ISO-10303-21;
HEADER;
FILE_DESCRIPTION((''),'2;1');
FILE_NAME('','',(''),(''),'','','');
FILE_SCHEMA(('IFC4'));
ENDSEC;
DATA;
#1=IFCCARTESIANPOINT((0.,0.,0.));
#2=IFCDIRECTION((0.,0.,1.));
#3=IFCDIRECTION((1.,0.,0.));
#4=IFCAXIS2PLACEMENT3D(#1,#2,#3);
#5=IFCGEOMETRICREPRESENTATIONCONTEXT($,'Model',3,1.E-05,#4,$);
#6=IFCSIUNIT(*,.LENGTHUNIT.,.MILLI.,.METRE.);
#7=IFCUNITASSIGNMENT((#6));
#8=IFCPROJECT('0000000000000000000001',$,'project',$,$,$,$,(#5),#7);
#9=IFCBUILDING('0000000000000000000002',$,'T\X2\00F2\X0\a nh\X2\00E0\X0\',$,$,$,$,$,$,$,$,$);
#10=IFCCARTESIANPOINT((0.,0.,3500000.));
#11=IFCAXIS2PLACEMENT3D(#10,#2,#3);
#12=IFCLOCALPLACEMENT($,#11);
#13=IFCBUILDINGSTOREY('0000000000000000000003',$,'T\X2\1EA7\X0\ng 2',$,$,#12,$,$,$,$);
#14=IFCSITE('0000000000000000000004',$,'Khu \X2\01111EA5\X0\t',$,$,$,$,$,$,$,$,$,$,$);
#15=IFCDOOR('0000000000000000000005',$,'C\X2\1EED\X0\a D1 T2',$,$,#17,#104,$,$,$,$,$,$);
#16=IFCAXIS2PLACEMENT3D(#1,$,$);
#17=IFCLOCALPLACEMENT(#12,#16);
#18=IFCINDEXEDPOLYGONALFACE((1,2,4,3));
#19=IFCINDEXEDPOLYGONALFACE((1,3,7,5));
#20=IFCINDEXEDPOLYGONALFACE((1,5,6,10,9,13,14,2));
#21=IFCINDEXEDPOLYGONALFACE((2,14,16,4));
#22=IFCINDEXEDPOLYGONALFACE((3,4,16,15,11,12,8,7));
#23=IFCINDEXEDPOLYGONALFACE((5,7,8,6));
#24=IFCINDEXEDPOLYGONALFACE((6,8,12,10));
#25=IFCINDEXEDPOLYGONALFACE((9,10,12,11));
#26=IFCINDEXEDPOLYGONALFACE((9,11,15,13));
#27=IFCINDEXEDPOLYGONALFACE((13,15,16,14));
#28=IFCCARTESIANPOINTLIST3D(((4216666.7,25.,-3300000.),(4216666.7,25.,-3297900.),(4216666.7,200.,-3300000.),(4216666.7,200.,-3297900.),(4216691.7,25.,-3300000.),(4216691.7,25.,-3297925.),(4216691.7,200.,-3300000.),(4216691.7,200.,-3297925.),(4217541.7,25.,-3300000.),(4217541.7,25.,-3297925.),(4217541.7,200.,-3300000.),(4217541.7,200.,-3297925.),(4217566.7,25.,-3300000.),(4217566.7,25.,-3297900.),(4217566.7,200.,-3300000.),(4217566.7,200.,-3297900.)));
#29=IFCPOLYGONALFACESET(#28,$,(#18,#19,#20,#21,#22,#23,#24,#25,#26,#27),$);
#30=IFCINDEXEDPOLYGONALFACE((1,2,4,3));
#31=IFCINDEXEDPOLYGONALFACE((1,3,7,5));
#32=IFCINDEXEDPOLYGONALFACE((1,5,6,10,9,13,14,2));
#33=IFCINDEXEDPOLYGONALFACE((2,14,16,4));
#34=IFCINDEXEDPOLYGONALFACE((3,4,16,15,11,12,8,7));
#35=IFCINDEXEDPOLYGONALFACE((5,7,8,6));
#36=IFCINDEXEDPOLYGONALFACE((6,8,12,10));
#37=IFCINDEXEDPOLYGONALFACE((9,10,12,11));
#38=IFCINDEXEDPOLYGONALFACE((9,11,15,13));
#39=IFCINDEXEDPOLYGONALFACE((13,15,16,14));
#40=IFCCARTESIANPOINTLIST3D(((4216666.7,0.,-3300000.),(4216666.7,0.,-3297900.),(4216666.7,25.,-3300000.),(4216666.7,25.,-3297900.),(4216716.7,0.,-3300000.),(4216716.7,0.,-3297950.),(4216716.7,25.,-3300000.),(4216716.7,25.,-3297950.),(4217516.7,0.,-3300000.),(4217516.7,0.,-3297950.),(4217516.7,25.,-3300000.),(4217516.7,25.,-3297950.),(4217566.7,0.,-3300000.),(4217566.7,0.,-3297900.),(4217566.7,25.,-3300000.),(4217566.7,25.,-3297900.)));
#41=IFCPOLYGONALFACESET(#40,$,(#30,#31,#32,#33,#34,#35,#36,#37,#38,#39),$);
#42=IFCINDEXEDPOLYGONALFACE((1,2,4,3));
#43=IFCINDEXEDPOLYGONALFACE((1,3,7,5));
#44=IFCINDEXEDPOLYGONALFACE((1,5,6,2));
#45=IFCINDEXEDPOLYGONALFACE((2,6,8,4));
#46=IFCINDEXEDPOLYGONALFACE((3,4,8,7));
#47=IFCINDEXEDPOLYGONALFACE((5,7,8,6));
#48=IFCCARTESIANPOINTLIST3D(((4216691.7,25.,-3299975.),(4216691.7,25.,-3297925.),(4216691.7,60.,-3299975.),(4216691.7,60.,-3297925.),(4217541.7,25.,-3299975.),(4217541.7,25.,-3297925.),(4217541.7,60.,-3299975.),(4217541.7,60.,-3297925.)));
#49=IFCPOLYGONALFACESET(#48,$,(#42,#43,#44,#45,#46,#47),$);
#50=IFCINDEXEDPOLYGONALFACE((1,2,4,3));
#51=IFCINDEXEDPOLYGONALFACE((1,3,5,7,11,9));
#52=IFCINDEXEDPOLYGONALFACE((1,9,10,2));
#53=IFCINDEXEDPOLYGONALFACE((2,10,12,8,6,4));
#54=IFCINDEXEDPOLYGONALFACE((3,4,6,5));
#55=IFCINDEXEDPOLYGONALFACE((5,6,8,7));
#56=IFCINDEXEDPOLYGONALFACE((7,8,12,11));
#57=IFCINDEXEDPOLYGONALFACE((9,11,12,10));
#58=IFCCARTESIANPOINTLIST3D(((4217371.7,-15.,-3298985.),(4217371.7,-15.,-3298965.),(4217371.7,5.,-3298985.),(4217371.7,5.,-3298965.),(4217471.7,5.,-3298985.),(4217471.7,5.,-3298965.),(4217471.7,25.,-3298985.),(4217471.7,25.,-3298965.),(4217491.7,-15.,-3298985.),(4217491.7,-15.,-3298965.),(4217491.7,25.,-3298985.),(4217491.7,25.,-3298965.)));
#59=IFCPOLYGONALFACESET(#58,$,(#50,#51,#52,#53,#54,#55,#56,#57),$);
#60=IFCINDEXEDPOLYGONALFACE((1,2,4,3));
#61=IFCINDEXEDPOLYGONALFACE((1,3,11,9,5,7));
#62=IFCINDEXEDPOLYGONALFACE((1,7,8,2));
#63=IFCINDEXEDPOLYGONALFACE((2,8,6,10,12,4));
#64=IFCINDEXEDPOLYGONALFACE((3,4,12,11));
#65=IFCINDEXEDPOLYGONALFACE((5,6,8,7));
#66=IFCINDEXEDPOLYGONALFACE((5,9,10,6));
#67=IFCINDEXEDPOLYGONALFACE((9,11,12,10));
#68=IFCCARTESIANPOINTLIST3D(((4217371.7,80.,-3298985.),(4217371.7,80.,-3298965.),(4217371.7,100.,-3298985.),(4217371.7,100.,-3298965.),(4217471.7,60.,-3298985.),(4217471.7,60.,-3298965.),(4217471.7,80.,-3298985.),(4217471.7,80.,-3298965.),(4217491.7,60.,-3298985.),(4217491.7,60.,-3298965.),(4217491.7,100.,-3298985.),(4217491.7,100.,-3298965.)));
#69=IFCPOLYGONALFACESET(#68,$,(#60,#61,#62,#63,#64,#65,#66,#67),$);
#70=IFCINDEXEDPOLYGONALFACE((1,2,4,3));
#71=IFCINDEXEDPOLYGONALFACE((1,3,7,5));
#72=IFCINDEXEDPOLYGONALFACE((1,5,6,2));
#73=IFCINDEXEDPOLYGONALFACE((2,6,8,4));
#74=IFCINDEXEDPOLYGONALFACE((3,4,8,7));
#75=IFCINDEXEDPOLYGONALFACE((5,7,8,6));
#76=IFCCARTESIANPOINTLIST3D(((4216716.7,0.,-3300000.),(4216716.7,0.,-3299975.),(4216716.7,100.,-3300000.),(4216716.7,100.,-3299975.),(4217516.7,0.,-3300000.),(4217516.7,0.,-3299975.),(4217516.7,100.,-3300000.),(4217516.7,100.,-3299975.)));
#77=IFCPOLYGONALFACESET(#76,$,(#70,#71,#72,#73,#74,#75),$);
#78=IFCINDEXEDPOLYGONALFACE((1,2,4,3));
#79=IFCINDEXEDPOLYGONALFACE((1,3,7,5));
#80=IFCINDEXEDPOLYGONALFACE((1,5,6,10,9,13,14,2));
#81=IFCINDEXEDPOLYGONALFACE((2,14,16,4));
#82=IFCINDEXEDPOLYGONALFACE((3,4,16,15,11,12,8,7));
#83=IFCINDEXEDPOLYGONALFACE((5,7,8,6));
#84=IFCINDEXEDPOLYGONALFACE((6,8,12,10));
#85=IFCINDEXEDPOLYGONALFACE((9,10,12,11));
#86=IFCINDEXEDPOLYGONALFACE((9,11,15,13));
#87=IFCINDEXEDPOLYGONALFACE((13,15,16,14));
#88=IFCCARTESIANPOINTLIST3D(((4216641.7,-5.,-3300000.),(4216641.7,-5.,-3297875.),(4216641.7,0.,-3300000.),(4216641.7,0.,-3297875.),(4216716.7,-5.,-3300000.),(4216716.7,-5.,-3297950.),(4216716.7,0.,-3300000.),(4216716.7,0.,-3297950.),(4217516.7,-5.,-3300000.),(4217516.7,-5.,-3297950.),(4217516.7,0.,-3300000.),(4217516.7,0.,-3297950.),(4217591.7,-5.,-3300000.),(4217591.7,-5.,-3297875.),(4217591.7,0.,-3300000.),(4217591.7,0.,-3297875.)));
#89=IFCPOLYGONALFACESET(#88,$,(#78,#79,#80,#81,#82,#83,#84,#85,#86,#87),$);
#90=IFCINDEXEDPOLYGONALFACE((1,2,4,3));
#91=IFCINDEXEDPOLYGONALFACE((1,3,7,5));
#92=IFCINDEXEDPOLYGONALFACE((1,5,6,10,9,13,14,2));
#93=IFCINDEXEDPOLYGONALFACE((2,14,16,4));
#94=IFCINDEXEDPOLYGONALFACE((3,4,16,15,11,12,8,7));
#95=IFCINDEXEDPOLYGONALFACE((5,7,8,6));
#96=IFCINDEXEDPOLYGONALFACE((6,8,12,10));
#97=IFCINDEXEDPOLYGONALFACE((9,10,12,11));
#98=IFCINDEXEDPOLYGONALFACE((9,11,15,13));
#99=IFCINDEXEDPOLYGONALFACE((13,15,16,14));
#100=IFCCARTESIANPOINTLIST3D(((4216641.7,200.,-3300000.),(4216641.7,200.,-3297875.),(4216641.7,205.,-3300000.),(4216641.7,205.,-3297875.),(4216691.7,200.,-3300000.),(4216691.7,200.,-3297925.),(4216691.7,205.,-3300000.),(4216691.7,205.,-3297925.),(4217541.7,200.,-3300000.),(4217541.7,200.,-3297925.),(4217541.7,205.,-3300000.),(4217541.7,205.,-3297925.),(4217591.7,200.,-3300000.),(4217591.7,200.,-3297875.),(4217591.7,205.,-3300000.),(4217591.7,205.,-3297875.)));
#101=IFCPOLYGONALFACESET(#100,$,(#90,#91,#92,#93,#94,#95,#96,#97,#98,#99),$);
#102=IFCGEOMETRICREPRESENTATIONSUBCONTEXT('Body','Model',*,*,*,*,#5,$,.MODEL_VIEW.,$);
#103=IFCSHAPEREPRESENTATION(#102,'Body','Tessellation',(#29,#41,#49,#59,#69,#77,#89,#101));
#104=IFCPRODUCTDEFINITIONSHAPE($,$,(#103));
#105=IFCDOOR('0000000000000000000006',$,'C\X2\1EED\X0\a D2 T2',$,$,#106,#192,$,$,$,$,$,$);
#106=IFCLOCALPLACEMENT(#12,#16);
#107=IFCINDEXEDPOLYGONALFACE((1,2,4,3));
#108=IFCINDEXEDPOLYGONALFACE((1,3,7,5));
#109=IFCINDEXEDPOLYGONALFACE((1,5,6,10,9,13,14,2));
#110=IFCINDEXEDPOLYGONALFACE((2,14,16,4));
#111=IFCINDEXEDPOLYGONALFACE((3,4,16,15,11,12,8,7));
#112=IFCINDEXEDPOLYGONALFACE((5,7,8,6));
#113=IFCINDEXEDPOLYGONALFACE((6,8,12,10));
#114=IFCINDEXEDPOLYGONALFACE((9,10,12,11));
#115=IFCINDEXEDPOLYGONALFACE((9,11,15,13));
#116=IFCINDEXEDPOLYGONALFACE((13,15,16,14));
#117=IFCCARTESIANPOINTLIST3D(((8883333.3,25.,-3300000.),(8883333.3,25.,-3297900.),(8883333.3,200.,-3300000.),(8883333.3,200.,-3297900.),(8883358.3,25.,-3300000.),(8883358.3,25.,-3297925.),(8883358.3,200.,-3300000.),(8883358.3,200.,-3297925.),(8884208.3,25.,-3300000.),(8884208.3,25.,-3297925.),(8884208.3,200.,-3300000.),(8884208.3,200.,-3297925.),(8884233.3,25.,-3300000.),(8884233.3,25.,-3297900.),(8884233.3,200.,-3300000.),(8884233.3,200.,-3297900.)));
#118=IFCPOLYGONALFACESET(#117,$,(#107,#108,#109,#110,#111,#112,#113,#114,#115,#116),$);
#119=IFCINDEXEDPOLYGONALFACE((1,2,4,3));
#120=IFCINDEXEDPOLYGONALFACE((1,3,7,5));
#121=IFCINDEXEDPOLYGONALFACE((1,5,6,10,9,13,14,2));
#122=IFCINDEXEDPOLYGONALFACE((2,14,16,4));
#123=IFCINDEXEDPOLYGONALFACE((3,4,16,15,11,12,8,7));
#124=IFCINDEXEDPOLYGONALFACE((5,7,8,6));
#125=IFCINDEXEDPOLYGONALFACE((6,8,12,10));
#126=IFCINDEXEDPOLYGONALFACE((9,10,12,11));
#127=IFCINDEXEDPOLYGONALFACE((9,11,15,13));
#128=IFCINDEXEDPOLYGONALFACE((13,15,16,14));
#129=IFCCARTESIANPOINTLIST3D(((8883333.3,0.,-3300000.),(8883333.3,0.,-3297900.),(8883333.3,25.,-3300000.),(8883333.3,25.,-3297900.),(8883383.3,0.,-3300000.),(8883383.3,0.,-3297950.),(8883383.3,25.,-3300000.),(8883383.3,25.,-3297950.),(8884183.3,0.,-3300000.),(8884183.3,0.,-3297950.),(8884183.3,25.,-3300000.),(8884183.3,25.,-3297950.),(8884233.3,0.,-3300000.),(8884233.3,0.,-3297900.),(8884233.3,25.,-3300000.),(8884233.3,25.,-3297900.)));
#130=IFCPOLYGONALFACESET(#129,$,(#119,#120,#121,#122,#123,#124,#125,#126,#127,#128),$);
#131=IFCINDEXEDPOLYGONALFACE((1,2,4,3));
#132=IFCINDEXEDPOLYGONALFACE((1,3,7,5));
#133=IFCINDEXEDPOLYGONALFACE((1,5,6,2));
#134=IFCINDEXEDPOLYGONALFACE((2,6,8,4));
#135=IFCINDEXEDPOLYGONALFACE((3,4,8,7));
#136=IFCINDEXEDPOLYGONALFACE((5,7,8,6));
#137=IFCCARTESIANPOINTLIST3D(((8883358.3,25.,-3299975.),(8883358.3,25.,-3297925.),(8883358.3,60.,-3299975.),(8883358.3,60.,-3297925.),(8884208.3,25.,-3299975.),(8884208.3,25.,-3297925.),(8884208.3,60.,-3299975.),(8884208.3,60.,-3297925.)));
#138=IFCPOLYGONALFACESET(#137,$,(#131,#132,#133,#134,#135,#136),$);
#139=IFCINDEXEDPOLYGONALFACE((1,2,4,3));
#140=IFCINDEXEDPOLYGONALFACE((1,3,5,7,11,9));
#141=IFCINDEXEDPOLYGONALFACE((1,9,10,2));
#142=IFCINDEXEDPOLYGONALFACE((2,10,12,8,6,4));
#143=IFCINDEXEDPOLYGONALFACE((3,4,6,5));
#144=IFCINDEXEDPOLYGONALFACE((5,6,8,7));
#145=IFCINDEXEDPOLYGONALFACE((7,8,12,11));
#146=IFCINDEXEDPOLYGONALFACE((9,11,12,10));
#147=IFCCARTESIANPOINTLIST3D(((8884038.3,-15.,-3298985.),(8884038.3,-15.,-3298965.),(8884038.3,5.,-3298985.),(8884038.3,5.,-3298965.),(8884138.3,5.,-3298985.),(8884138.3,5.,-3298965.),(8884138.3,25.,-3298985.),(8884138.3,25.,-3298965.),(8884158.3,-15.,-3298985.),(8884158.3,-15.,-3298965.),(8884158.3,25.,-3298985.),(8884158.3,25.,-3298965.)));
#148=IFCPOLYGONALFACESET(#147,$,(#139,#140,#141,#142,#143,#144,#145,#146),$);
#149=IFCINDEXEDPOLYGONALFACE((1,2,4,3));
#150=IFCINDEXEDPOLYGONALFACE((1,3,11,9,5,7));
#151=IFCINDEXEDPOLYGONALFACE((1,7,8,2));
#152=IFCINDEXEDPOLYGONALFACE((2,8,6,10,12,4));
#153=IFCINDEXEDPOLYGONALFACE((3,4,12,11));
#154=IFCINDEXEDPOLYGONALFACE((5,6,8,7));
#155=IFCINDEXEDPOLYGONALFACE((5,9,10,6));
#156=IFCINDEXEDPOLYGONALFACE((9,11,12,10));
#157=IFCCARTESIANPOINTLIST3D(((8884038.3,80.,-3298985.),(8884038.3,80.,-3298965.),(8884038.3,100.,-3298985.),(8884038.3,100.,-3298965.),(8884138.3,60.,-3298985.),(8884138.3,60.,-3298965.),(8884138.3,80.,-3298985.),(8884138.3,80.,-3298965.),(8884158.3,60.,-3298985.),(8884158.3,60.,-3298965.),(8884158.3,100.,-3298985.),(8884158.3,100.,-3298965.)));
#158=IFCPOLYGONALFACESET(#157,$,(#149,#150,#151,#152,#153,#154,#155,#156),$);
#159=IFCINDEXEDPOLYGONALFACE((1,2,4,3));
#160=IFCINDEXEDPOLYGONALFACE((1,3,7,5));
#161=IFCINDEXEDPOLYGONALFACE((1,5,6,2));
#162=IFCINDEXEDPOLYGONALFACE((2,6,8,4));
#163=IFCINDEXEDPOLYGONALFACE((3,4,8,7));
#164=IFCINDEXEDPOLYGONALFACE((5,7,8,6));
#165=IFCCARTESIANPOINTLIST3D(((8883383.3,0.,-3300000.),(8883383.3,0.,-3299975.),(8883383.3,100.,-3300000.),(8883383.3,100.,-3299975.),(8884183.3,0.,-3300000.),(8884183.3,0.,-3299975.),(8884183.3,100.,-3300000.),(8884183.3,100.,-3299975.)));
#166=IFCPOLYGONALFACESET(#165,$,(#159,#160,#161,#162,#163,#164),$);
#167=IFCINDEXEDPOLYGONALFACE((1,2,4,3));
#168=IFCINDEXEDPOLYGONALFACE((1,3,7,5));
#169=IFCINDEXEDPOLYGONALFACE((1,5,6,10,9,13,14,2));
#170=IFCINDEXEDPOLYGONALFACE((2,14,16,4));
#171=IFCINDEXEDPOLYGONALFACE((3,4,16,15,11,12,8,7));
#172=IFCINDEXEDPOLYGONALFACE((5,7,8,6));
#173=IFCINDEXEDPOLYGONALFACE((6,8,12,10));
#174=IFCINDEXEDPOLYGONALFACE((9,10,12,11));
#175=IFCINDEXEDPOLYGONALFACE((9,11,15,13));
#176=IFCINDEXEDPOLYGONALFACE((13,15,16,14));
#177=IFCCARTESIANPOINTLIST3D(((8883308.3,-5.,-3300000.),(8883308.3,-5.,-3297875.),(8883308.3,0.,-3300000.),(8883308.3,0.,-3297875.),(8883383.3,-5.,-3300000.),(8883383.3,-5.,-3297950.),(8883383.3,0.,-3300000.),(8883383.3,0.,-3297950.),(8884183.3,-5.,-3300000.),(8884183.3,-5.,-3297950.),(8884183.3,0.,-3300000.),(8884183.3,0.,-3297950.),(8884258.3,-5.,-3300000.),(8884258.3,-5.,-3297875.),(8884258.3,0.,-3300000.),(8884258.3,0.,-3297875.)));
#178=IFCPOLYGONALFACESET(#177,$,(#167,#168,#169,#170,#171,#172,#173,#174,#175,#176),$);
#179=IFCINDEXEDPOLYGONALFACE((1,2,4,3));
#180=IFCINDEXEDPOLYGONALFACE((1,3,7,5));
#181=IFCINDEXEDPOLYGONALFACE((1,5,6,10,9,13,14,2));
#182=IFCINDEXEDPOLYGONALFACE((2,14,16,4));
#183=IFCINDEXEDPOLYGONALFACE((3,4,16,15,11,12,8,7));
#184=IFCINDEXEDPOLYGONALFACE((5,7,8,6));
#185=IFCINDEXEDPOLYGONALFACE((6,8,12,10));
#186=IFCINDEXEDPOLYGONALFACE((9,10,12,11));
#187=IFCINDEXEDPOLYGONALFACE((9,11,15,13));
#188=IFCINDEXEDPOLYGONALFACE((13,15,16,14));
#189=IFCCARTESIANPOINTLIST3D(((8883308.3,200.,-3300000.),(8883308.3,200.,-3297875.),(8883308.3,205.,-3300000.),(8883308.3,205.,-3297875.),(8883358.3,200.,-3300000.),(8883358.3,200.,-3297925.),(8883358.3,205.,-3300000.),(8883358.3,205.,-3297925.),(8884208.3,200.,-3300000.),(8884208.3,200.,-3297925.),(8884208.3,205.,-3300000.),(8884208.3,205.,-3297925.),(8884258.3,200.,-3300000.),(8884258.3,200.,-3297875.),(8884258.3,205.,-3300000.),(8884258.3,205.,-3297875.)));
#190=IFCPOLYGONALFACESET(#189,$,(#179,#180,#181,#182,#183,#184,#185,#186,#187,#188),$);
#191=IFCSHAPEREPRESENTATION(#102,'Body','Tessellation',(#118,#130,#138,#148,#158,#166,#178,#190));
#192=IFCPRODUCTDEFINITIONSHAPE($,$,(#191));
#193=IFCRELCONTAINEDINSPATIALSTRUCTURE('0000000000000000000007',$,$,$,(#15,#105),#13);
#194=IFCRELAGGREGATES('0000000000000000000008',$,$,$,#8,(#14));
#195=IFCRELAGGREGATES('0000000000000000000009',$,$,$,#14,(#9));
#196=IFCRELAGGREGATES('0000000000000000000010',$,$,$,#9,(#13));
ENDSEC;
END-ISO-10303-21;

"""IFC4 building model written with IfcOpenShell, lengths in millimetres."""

from ifc_helpers import new_model, si_unit, frame, origin_with_axes, place, context, subcontext, project, spatial, line, indexed_curve, outline, extrude, element, save


model = new_model("IFC4")

# Units and contexts
model_context = context("Model", 3, precision=1e-05, world=origin_with_axes())
body_context = subcontext(model_context, "Body", "Model", "MODEL_VIEW")
ifc_project = project(units=[si_unit("LENGTHUNIT", "METRE", prefix="MILLI")], contexts=[model_context])

# Site, building, storey
site = spatial("IfcSite", under=ifc_project, Name="Khu đất")
building = spatial("IfcBuilding", under=site, Name="Tòa nhà")
storey_placement = place(None, frame((0.0, 0.0, 3500000.0), z_axis=(0.0, 0.0, 1.0), x_axis=(1.0, 0.0, 0.0)))
storey = spatial("IfcBuildingStorey", under=building, at=storey_placement, Name="Tầng 2")

# Doors
door_1_placement = place(storey_placement, frame((4216666.7, 0.0, -3300000.0), z_axis=(0.0, 0.0, 1.0), x_axis=(1.0, 0.0, 0.0)))
element("IfcDoor", 1, at=door_1_placement, inside=storey, Name="Cửa D1 T2", context=body_context, shape_type="SolidModel", body=[
    extrude(outline(indexed_curve([(0.0, 0.0), (0.0, 2100.0), (900.0, 2100.0), (900.0, 0.0), (875.0, 0.0), (875.0, 2075.0), (25.0, 2075.0), (25.0, 0.0)], segments=[line(1, 2, 3, 4, 5, 6, 7, 8, 1)])), frame((0.0, 25.0, 0.0), z_axis=(0.0, -1.0, 0.0), x_axis=(1.0, 0.0, 0.0)), (0.0, 0.0, -1.0), 175.0),
    extrude(outline(indexed_curve([(0.0, 0.0), (0.0, 2100.0), (900.0, 2100.0), (900.0, 0.0), (850.0, 0.0), (850.0, 2050.0), (50.0, 2050.0), (50.0, 0.0)], segments=[line(1, 2, 3, 4, 5, 6, 7, 8, 1)])), frame((0.0, 0.0, 0.0), z_axis=(0.0, -1.0, 0.0), x_axis=(1.0, 0.0, 0.0)), (0.0, 0.0, -1.0), 25.0),
    extrude(outline(indexed_curve([(0.0, 0.0), (850.0, 0.0), (850.0, 35.0), (0.0, 35.0)], segments=[line(1, 2, 3, 4, 1)])), frame((25.0, 25.0, 25.0), z_axis=(0.0, 0.0, 1.0), x_axis=(1.0, 0.0, 0.0)), (0.0, 0.0, 1.0), 2050.0),
    extrude(outline(indexed_curve([(0.0, 0.0), (0.0, -40.0), (-120.0, -40.0), (-120.0, -20.0), (-20.0, -20.0), (-20.0, 0.0)], segments=[line(1, 2, 3, 4, 5, 6, 1)])), frame((825.0, 25.0, 1015.0), z_axis=(0.0, 0.0, 1.0), x_axis=(1.0, 0.0, 0.0)), (0.0, 0.0, 1.0), 20.0),
    extrude(outline(indexed_curve([(0.0, 0.0), (0.0, 40.0), (-120.0, 40.0), (-120.0, 20.0), (-20.0, 20.0), (-20.0, 0.0)], segments=[line(1, 2, 3, 4, 5, 6, 1)])), frame((825.0, 60.0, 1015.0), z_axis=(0.0, 0.0, 1.0), x_axis=(1.0, 0.0, 0.0)), (0.0, 0.0, 1.0), 20.0),
    extrude(outline(indexed_curve([(0.0, 0.0), (800.0, 0.0), (800.0, 100.0), (0.0, 100.0)], segments=[line(1, 2, 3, 4, 1)])), frame((50.0, 0.0, 0.0), z_axis=(0.0, 0.0, 1.0), x_axis=(1.0, 0.0, 0.0)), (0.0, 0.0, 1.0), 25.0),
    extrude(outline(indexed_curve([(0.0, 0.0), (0.0, 2125.0), (950.0, 2125.0), (950.0, 0.0), (875.0, 0.0), (875.0, 2050.0), (75.0, 2050.0), (75.0, 0.0)], segments=[line(1, 2, 3, 4, 5, 6, 7, 8, 1)])), frame((-25.0, -5.0, 0.0), z_axis=(0.0, -1.0, 0.0), x_axis=(1.0, 0.0, 0.0)), (0.0, 0.0, -1.0), 5.0),
    extrude(outline(indexed_curve([(0.0, 0.0), (0.0, 2125.0), (950.0, 2125.0), (950.0, 0.0), (900.0, 0.0), (900.0, 2075.0), (50.0, 2075.0), (50.0, 0.0)], segments=[line(1, 2, 3, 4, 5, 6, 7, 8, 1)])), frame((-25.0, 200.0, 0.0), z_axis=(0.0, -1.0, 0.0), x_axis=(1.0, 0.0, 0.0)), (0.0, 0.0, -1.0), 5.0),
])
door_2_placement = place(storey_placement, frame((8883333.3, 0.0, -3300000.0), z_axis=(0.0, 0.0, 1.0), x_axis=(1.0, 0.0, 0.0)))
element("IfcDoor", 2, at=door_2_placement, inside=storey, Name="Cửa D2 T2", context=body_context, shape_type="SolidModel", body=[
    extrude(outline(indexed_curve([(0.0, 0.0), (0.0, 2100.0), (900.0, 2100.0), (900.0, 0.0), (875.0, 0.0), (875.0, 2075.0), (25.0, 2075.0), (25.0, 0.0)], segments=[line(1, 2, 3, 4, 5, 6, 7, 8, 1)])), frame((0.0, 25.0, 0.0), z_axis=(0.0, -1.0, 0.0), x_axis=(1.0, 0.0, 0.0)), (0.0, 0.0, -1.0), 175.0),
    extrude(outline(indexed_curve([(0.0, 0.0), (0.0, 2100.0), (900.0, 2100.0), (900.0, 0.0), (850.0, 0.0), (850.0, 2050.0), (50.0, 2050.0), (50.0, 0.0)], segments=[line(1, 2, 3, 4, 5, 6, 7, 8, 1)])), frame((0.0, 0.0, 0.0), z_axis=(0.0, -1.0, 0.0), x_axis=(1.0, 0.0, 0.0)), (0.0, 0.0, -1.0), 25.0),
    extrude(outline(indexed_curve([(0.0, 0.0), (850.0, 0.0), (850.0, 35.0), (0.0, 35.0)], segments=[line(1, 2, 3, 4, 1)])), frame((25.0, 25.0, 25.0), z_axis=(0.0, 0.0, 1.0), x_axis=(1.0, 0.0, 0.0)), (0.0, 0.0, 1.0), 2050.0),
    extrude(outline(indexed_curve([(0.0, 0.0), (0.0, -40.0), (-120.0, -40.0), (-120.0, -20.0), (-20.0, -20.0), (-20.0, 0.0)], segments=[line(1, 2, 3, 4, 5, 6, 1)])), frame((825.0, 25.0, 1015.0), z_axis=(0.0, 0.0, 1.0), x_axis=(1.0, 0.0, 0.0)), (0.0, 0.0, 1.0), 20.0),
    extrude(outline(indexed_curve([(0.0, 0.0), (0.0, 40.0), (-120.0, 40.0), (-120.0, 20.0), (-20.0, 20.0), (-20.0, 0.0)], segments=[line(1, 2, 3, 4, 5, 6, 1)])), frame((825.0, 60.0, 1015.0), z_axis=(0.0, 0.0, 1.0), x_axis=(1.0, 0.0, 0.0)), (0.0, 0.0, 1.0), 20.0),
    extrude(outline(indexed_curve([(0.0, 0.0), (800.0, 0.0), (800.0, 100.0), (0.0, 100.0)], segments=[line(1, 2, 3, 4, 1)])), frame((50.0, 0.0, 0.0), z_axis=(0.0, 0.0, 1.0), x_axis=(1.0, 0.0, 0.0)), (0.0, 0.0, 1.0), 25.0),
    extrude(outline(indexed_curve([(0.0, 0.0), (0.0, 2125.0), (950.0, 2125.0), (950.0, 0.0), (875.0, 0.0), (875.0, 2050.0), (75.0, 2050.0), (75.0, 0.0)], segments=[line(1, 2, 3, 4, 5, 6, 7, 8, 1)])), frame((-25.0, -5.0, 0.0), z_axis=(0.0, -1.0, 0.0), x_axis=(1.0, 0.0, 0.0)), (0.0, 0.0, -1.0), 5.0),
    extrude(outline(indexed_curve([(0.0, 0.0), (0.0, 2125.0), (950.0, 2125.0), (950.0, 0.0), (900.0, 0.0), (900.0, 2075.0), (50.0, 2075.0), (50.0, 0.0)], segments=[line(1, 2, 3, 4, 5, 6, 7, 8, 1)])), frame((-25.0, 200.0, 0.0), z_axis=(0.0, -1.0, 0.0), x_axis=(1.0, 0.0, 0.0)), (0.0, 0.0, -1.0), 5.0),
])

save(model, "model.ifc")
